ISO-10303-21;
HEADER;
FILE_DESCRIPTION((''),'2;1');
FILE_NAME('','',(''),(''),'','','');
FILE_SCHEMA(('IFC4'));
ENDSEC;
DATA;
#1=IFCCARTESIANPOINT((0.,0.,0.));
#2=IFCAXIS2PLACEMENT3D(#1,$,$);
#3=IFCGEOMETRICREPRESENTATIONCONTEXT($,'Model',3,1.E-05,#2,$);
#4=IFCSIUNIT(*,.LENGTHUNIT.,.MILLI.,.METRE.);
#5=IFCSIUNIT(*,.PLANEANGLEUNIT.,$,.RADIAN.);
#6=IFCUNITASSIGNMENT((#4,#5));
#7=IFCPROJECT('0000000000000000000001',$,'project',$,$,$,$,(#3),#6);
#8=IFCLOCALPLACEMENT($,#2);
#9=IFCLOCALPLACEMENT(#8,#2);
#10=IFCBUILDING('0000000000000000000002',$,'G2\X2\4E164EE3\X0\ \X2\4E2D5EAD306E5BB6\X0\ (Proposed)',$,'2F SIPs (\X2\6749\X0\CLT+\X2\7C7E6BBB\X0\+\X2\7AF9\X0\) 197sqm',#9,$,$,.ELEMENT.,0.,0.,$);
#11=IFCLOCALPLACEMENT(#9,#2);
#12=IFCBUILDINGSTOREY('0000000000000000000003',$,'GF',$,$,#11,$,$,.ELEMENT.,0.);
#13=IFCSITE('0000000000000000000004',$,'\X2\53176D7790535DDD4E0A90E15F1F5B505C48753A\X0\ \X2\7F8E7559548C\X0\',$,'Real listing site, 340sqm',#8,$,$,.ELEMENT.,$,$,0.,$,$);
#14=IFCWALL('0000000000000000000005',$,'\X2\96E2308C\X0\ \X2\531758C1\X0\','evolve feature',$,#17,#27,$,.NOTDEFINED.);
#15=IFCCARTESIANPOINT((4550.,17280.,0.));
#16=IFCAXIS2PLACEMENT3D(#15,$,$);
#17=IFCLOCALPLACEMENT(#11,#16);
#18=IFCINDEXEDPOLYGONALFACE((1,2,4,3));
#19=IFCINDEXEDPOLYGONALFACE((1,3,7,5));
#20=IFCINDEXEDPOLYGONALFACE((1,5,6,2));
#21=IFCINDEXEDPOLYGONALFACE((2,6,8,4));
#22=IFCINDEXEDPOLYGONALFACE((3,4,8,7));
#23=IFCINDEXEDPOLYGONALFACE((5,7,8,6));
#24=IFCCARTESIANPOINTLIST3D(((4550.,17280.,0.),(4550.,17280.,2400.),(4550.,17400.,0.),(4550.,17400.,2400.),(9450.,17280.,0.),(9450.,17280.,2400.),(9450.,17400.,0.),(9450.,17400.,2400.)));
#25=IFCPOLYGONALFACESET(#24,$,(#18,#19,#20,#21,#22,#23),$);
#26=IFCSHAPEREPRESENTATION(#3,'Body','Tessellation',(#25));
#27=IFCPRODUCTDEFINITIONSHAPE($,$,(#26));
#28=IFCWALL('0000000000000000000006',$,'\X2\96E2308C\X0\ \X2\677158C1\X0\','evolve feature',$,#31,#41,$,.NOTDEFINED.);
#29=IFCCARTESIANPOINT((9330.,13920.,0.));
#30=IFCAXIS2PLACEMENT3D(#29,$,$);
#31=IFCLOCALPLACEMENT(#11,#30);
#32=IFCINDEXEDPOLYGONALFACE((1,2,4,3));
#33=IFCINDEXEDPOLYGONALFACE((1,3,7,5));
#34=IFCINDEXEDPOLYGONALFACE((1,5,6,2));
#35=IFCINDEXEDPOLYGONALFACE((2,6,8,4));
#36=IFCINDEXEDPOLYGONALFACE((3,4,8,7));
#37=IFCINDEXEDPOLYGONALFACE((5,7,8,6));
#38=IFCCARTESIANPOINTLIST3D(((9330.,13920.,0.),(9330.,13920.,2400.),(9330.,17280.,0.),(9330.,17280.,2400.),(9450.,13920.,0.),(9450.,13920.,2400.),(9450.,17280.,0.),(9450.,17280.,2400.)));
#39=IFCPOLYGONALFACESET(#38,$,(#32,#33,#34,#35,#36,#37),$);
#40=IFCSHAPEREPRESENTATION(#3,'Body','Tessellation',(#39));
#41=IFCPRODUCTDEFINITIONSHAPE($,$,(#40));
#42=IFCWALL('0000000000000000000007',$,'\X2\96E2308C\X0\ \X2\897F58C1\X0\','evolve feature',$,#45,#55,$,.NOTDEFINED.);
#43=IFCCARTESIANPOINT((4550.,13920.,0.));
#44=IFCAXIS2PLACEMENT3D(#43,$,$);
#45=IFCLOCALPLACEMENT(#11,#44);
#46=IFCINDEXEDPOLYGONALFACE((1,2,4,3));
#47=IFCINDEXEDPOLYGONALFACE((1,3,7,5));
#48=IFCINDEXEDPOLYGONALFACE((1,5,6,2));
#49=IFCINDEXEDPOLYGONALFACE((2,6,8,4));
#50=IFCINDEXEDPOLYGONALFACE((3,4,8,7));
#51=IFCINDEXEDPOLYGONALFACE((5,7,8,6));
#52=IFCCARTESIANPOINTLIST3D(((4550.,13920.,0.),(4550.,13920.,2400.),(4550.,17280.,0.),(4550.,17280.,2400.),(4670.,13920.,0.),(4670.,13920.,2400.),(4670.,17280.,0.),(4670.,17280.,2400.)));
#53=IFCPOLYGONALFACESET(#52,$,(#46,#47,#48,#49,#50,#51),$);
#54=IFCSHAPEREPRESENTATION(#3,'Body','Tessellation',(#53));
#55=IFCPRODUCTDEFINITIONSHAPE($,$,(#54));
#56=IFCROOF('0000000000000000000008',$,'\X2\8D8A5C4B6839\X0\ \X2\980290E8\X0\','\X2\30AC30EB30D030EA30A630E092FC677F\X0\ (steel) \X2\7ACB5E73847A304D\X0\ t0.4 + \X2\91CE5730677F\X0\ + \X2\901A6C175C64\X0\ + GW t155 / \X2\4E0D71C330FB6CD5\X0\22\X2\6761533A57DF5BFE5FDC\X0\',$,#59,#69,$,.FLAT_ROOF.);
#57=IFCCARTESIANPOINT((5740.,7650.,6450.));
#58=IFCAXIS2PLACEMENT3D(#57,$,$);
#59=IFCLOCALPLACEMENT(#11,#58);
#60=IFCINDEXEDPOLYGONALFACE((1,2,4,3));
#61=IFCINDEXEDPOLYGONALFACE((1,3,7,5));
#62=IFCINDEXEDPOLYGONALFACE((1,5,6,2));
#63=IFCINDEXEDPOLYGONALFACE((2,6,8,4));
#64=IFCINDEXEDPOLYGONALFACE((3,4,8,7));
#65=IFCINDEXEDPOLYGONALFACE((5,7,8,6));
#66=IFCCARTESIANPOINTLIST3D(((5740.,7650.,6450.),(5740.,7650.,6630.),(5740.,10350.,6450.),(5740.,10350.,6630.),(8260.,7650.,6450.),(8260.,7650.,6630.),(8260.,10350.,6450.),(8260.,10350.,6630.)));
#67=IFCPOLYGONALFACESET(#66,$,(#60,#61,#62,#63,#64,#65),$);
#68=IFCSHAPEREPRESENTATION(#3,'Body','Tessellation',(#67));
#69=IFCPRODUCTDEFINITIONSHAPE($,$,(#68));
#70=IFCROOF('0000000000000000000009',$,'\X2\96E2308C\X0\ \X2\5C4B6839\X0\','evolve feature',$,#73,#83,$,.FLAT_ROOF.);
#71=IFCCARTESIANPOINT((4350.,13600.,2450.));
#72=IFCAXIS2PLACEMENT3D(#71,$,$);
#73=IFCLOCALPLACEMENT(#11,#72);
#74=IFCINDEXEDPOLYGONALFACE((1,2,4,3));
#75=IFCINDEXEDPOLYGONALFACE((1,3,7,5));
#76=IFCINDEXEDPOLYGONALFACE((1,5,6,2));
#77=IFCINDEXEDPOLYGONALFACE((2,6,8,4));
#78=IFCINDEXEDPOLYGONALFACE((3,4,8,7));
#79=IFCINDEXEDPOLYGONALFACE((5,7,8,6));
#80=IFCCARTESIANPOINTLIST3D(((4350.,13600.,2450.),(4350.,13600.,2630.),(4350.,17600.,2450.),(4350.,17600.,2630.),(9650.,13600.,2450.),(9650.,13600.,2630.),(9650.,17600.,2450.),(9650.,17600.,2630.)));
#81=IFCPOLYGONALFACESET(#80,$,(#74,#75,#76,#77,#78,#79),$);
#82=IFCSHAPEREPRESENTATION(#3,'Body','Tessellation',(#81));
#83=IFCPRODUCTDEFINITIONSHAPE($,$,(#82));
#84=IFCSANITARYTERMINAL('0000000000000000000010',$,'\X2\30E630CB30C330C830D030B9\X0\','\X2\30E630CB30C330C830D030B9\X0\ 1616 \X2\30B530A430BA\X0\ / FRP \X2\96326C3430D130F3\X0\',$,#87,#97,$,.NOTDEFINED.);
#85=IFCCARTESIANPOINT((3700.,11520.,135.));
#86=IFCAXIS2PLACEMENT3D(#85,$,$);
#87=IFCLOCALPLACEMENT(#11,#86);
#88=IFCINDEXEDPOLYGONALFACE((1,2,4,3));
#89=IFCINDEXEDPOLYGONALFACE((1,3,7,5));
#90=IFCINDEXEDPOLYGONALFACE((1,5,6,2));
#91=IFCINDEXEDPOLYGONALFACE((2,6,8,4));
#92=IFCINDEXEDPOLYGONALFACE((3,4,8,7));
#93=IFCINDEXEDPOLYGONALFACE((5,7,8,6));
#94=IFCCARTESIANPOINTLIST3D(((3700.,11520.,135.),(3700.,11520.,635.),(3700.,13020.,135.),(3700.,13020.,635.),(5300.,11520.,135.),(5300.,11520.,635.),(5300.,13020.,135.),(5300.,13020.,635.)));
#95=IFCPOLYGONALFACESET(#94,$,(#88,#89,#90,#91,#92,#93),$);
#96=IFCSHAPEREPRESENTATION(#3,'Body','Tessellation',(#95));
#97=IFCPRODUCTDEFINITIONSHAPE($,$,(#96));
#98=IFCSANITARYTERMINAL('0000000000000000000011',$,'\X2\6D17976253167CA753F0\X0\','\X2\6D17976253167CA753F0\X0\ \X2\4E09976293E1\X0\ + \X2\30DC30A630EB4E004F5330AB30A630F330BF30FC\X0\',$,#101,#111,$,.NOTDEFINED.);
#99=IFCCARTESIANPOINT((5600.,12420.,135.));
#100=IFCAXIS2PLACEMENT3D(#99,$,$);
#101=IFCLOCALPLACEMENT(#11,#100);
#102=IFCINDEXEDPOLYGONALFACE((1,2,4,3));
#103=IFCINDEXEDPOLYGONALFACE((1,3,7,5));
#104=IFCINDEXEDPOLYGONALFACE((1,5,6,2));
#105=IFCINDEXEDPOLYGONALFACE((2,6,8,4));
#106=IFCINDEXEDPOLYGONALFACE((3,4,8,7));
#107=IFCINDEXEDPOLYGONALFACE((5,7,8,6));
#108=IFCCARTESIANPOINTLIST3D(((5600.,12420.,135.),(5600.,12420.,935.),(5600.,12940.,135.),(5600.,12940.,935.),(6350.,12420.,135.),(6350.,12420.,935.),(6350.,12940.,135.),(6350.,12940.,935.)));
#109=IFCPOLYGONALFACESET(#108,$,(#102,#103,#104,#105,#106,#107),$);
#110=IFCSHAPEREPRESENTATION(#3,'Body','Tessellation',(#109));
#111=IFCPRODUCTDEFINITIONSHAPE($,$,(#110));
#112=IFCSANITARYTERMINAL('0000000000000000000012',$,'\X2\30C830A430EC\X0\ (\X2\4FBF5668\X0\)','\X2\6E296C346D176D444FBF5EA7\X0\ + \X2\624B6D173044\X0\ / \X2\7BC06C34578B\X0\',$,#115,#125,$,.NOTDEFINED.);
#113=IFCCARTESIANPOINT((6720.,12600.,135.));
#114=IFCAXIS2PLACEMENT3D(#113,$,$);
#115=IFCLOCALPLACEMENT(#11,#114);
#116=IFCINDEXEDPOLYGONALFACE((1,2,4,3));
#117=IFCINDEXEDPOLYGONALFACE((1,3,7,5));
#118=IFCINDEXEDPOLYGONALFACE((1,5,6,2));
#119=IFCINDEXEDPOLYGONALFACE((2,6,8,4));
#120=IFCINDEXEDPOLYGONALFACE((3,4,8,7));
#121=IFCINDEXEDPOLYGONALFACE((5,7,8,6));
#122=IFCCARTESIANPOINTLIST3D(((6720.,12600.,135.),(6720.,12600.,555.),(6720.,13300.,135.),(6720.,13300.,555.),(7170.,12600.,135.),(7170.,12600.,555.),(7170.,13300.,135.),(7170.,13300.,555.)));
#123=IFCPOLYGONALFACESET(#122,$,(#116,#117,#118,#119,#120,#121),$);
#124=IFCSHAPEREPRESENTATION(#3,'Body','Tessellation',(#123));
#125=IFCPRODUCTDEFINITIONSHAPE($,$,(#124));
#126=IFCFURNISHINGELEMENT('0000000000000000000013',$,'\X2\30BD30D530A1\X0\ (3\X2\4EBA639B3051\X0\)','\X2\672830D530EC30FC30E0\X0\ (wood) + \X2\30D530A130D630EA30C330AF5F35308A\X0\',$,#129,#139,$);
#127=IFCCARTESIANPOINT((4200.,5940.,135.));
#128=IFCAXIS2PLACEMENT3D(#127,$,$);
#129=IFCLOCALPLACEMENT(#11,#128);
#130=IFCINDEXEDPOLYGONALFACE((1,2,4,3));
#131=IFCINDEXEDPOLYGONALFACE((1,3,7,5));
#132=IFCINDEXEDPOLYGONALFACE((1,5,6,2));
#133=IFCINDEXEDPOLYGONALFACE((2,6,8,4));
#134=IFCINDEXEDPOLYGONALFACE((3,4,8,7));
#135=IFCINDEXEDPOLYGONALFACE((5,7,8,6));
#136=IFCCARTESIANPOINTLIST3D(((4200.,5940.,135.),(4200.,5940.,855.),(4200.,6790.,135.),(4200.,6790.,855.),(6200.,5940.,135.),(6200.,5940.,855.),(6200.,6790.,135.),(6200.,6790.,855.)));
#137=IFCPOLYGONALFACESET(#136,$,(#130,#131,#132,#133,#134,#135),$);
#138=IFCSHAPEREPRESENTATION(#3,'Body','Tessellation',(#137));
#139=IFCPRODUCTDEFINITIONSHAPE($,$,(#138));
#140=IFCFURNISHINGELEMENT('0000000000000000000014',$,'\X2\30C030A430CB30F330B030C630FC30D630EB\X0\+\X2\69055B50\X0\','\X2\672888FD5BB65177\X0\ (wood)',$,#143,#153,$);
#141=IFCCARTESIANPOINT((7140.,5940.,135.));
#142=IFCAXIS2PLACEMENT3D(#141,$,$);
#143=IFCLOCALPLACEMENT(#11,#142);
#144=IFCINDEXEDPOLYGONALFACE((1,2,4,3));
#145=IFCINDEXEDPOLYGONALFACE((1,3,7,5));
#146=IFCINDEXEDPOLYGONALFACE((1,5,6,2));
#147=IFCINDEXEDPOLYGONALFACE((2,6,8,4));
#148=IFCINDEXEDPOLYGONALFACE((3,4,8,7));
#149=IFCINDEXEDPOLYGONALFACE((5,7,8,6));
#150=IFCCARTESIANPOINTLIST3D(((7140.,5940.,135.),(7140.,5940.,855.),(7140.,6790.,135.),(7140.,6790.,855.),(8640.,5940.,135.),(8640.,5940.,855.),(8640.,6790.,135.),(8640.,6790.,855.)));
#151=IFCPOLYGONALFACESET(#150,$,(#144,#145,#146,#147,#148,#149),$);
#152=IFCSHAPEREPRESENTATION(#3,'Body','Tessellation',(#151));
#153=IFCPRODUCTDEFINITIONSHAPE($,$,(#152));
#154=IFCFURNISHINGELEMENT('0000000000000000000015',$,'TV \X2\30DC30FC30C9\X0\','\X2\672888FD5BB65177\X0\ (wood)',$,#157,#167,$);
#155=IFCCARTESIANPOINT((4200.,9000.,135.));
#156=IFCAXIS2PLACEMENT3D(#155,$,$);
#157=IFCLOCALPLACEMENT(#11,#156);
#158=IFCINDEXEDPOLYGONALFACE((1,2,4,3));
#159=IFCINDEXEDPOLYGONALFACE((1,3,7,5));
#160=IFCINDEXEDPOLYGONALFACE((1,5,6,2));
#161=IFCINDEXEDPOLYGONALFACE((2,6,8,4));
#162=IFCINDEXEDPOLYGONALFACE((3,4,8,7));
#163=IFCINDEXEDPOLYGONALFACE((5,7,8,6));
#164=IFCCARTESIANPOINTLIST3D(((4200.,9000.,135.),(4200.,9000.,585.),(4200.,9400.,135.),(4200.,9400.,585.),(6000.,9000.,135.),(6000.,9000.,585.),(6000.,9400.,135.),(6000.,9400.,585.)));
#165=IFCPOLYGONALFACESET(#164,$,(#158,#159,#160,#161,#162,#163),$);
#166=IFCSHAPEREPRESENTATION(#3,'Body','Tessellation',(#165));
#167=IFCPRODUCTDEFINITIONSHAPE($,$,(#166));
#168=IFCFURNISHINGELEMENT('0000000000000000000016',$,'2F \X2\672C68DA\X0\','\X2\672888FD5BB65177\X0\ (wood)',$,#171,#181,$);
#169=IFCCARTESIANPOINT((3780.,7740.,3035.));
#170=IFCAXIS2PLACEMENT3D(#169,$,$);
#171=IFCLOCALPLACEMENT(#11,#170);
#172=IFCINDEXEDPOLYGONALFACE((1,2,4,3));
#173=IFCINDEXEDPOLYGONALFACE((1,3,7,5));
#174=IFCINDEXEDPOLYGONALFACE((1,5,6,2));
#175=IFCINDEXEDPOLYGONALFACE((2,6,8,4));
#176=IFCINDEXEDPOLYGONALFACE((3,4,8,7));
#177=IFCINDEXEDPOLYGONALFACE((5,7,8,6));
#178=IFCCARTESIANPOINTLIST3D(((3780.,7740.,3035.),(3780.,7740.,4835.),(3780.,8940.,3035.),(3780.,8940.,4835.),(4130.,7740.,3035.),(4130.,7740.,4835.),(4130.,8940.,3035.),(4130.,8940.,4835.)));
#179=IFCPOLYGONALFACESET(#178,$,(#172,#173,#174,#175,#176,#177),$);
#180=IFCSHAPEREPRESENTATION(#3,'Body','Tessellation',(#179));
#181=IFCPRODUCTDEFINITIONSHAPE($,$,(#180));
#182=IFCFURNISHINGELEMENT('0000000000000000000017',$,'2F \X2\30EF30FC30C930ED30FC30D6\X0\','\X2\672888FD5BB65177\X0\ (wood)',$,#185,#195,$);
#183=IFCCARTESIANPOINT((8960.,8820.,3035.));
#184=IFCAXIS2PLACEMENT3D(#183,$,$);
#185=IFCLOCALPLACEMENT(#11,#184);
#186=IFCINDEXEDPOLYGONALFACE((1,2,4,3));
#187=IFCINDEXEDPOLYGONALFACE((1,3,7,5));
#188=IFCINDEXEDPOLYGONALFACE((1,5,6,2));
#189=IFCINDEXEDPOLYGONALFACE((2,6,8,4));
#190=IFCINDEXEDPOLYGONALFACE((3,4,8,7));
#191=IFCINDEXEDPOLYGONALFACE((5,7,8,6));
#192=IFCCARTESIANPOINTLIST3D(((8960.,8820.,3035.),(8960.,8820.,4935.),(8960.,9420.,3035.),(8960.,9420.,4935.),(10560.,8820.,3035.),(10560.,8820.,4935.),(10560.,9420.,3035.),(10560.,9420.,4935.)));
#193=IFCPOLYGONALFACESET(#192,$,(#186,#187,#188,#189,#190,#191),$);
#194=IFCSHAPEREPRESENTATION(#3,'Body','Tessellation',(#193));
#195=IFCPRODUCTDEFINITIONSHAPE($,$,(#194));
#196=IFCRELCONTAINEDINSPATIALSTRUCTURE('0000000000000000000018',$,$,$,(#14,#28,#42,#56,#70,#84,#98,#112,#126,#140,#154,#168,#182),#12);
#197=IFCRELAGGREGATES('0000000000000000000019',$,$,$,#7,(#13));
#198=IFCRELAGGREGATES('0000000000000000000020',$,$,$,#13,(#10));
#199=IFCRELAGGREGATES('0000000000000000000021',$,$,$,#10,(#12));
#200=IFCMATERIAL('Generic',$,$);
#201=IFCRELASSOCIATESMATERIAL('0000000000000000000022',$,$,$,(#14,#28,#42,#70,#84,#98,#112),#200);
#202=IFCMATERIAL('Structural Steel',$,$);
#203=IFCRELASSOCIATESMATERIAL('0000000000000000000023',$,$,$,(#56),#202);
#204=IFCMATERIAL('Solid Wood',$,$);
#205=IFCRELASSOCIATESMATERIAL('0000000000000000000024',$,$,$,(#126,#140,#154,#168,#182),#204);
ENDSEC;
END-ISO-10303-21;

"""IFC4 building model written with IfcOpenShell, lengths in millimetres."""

from ifc_helpers import new_model, si_unit, frame, frame_2d, origin, place, context, project, spatial, rectangle, extrude, material, element, save


model = new_model("IFC4")

# Units and contexts
model_context = context("Model", 3, precision=1e-05, world=origin())
ifc_project = project(units=[si_unit("LENGTHUNIT", "METRE", prefix="MILLI"), si_unit("PLANEANGLEUNIT", "RADIAN")], contexts=[model_context])

# Site, building, storey
site_placement = place(None, origin())
site = spatial("IfcSite", under=ifc_project, at=site_placement, Name="北海道川上郡弟子屈町 美留和", ObjectType="Real listing site, 340sqm", CompositionType="ELEMENT", RefElevation=0.0)
building_placement = place(site_placement, origin())
building = spatial("IfcBuilding", under=site, at=building_placement, Name="G2世代 中庭の家 (Proposed)", ObjectType="2F SIPs (杉CLT+籾殻+竹) 197sqm", CompositionType="ELEMENT", ElevationOfRefHeight=0.0, ElevationOfTerrain=0.0)
storey_placement = place(building_placement, origin())
storey = spatial("IfcBuildingStorey", under=building, at=storey_placement, Name="GF", CompositionType="ELEMENT", Elevation=0.0)

# Shared definitions
ifc_material_1 = material(Name="Generic")

# Shared definitions
ifc_material_2 = material(Name="Solid Wood")

# Walls
wall_1_placement = place(storey_placement, frame((4550.0, 17280.0, 0.0)))
element("IfcWall", 1, at=wall_1_placement, inside=storey, material=ifc_material_1, Name="離れ 北壁", Description="evolve feature", PredefinedType="NOTDEFINED", context=model_context, shape_type="SweptSolid", body=[
    extrude(rectangle(XDim=4900.0, YDim=120.0, at=frame_2d((2450.0, 60.0))), frame((4550.0, 17280.0, 0.0)), (0.0, 0.0, 1.0), 2400.0),
])
wall_2_placement = place(storey_placement, frame((9330.0, 13920.0, 0.0)))
element("IfcWall", 2, at=wall_2_placement, inside=storey, material=ifc_material_1, Name="離れ 東壁", Description="evolve feature", PredefinedType="NOTDEFINED", context=model_context, shape_type="SweptSolid", body=[
    extrude(rectangle(XDim=120.0, YDim=3360.0, at=frame_2d((60.0, 1680.0))), frame((9330.0, 13920.0, 0.0)), (0.0, 0.0, 1.0), 2400.0),
])
wall_3_placement = place(storey_placement, frame((4550.0, 13920.0, 0.0)))
element("IfcWall", 3, at=wall_3_placement, inside=storey, material=ifc_material_1, Name="離れ 西壁", Description="evolve feature", PredefinedType="NOTDEFINED", context=model_context, shape_type="SweptSolid", body=[
    extrude(rectangle(XDim=120.0, YDim=3360.0, at=frame_2d((60.0, 1680.0))), frame((4550.0, 13920.0, 0.0)), (0.0, 0.0, 1.0), 2400.0),
])

# Roofs
ifc_material_3 = material(Name="Structural Steel")
roof_1_placement = place(storey_placement, frame((5740.0, 7650.0, 6450.0)))
element("IfcRoof", 4, at=roof_1_placement, inside=storey, material=ifc_material_3, Name="越屋根 頂部", Description="ガルバリウム鋼板 (steel) 立平葺き t0.4 + 野地板 + 通気層 + GW t155 / 不燃・法22条区域対応", PredefinedType="FLAT_ROOF", context=model_context, shape_type="SweptSolid", body=[
    extrude(rectangle(XDim=2520.0, YDim=2700.0, at=frame_2d((1260.0, 1350.0))), frame((5740.0, 7650.0, 6450.0)), (0.0, 0.0, 1.0), 180.0),
])
roof_2_placement = place(storey_placement, frame((4350.0, 13600.0, 2450.0)))
element("IfcRoof", 5, at=roof_2_placement, inside=storey, material=ifc_material_1, Name="離れ 屋根", Description="evolve feature", PredefinedType="FLAT_ROOF", context=model_context, shape_type="SweptSolid", body=[
    extrude(rectangle(XDim=5300.0, YDim=4000.0, at=frame_2d((2650.0, 2000.0))), frame((4350.0, 13600.0, 2450.0)), (0.0, 0.0, 1.0), 180.0),
])

# Sanitary terminals
sanitary_terminal_1_placement = place(storey_placement, frame((3700.0, 11520.0, 135.0)))
element("IfcSanitaryTerminal", 6, at=sanitary_terminal_1_placement, inside=storey, material=ifc_material_1, Name="ユニットバス", Description="ユニットバス 1616 サイズ / FRP 防水パン", PredefinedType="NOTDEFINED", context=model_context, shape_type="SweptSolid", body=[
    extrude(rectangle(XDim=1600.0, YDim=1500.0, at=frame_2d((800.0, 750.0))), frame((3700.0, 11520.0, 135.0)), (0.0, 0.0, 1.0), 500.0),
])
sanitary_terminal_2_placement = place(storey_placement, frame((5600.0, 12420.0, 135.0)))
element("IfcSanitaryTerminal", 7, at=sanitary_terminal_2_placement, inside=storey, material=ifc_material_1, Name="洗面化粧台", Description="洗面化粧台 三面鏡 + ボウル一体カウンター", PredefinedType="NOTDEFINED", context=model_context, shape_type="SweptSolid", body=[
    extrude(rectangle(XDim=750.0, YDim=520.0, at=frame_2d((375.0, 260.0))), frame((5600.0, 12420.0, 135.0)), (0.0, 0.0, 1.0), 800.0),
])
sanitary_terminal_3_placement = place(storey_placement, frame((6720.0, 12600.0, 135.0)))
element("IfcSanitaryTerminal", 8, at=sanitary_terminal_3_placement, inside=storey, material=ifc_material_1, Name="トイレ (便器)", Description="温水洗浄便座 + 手洗い / 節水型", PredefinedType="NOTDEFINED", context=model_context, shape_type="SweptSolid", body=[
    extrude(rectangle(XDim=450.0, YDim=700.0, at=frame_2d((225.0, 350.0))), frame((6720.0, 12600.0, 135.0)), (0.0, 0.0, 1.0), 420.0),
])

# Furnishing elements
furnishing_1_placement = place(storey_placement, frame((4200.0, 5940.0, 135.0)))
element("IfcFurnishingElement", 9, at=furnishing_1_placement, inside=storey, material=ifc_material_2, Name="ソファ (3人掛け)", Description="木フレーム (wood) + ファブリック張り", context=model_context, shape_type="SweptSolid", body=[
    extrude(rectangle(XDim=2000.0, YDim=850.0, at=frame_2d((1000.0, 425.0))), frame((4200.0, 5940.0, 135.0)), (0.0, 0.0, 1.0), 720.0),
])
furnishing_2_placement = place(storey_placement, frame((7140.0, 5940.0, 135.0)))
element("IfcFurnishingElement", 10, at=furnishing_2_placement, inside=storey, material=ifc_material_2, Name="ダイニングテーブル+椅子", Description="木製家具 (wood)", context=model_context, shape_type="SweptSolid", body=[
    extrude(rectangle(XDim=1500.0, YDim=850.0, at=frame_2d((750.0, 425.0))), frame((7140.0, 5940.0, 135.0)), (0.0, 0.0, 1.0), 720.0),
])
furnishing_3_placement = place(storey_placement, frame((4200.0, 9000.0, 135.0)))
element("IfcFurnishingElement", 11, at=furnishing_3_placement, inside=storey, material=ifc_material_2, Name="TV ボード", Description="木製家具 (wood)", context=model_context, shape_type="SweptSolid", body=[
    extrude(rectangle(XDim=1800.0, YDim=400.0, at=frame_2d((900.0, 200.0))), frame((4200.0, 9000.0, 135.0)), (0.0, 0.0, 1.0), 450.0),
])
furnishing_4_placement = place(storey_placement, frame((3780.0, 7740.0, 3035.0)))
element("IfcFurnishingElement", 12, at=furnishing_4_placement, inside=storey, material=ifc_material_2, Name="2F 本棚", Description="木製家具 (wood)", context=model_context, shape_type="SweptSolid", body=[
    extrude(rectangle(XDim=350.0, YDim=1200.0, at=frame_2d((175.0, 600.0))), frame((3780.0, 7740.0, 3035.0)), (0.0, 0.0, 1.0), 1800.0),
])
furnishing_5_placement = place(storey_placement, frame((8960.0, 8820.0, 3035.0)))
element("IfcFurnishingElement", 13, at=furnishing_5_placement, inside=storey, material=ifc_material_2, Name="2F ワードローブ", Description="木製家具 (wood)", context=model_context, shape_type="SweptSolid", body=[
    extrude(rectangle(XDim=1600.0, YDim=600.0, at=frame_2d((800.0, 300.0))), frame((8960.0, 8820.0, 3035.0)), (0.0, 0.0, 1.0), 1900.0),
])

save(model, "model.ifc")
